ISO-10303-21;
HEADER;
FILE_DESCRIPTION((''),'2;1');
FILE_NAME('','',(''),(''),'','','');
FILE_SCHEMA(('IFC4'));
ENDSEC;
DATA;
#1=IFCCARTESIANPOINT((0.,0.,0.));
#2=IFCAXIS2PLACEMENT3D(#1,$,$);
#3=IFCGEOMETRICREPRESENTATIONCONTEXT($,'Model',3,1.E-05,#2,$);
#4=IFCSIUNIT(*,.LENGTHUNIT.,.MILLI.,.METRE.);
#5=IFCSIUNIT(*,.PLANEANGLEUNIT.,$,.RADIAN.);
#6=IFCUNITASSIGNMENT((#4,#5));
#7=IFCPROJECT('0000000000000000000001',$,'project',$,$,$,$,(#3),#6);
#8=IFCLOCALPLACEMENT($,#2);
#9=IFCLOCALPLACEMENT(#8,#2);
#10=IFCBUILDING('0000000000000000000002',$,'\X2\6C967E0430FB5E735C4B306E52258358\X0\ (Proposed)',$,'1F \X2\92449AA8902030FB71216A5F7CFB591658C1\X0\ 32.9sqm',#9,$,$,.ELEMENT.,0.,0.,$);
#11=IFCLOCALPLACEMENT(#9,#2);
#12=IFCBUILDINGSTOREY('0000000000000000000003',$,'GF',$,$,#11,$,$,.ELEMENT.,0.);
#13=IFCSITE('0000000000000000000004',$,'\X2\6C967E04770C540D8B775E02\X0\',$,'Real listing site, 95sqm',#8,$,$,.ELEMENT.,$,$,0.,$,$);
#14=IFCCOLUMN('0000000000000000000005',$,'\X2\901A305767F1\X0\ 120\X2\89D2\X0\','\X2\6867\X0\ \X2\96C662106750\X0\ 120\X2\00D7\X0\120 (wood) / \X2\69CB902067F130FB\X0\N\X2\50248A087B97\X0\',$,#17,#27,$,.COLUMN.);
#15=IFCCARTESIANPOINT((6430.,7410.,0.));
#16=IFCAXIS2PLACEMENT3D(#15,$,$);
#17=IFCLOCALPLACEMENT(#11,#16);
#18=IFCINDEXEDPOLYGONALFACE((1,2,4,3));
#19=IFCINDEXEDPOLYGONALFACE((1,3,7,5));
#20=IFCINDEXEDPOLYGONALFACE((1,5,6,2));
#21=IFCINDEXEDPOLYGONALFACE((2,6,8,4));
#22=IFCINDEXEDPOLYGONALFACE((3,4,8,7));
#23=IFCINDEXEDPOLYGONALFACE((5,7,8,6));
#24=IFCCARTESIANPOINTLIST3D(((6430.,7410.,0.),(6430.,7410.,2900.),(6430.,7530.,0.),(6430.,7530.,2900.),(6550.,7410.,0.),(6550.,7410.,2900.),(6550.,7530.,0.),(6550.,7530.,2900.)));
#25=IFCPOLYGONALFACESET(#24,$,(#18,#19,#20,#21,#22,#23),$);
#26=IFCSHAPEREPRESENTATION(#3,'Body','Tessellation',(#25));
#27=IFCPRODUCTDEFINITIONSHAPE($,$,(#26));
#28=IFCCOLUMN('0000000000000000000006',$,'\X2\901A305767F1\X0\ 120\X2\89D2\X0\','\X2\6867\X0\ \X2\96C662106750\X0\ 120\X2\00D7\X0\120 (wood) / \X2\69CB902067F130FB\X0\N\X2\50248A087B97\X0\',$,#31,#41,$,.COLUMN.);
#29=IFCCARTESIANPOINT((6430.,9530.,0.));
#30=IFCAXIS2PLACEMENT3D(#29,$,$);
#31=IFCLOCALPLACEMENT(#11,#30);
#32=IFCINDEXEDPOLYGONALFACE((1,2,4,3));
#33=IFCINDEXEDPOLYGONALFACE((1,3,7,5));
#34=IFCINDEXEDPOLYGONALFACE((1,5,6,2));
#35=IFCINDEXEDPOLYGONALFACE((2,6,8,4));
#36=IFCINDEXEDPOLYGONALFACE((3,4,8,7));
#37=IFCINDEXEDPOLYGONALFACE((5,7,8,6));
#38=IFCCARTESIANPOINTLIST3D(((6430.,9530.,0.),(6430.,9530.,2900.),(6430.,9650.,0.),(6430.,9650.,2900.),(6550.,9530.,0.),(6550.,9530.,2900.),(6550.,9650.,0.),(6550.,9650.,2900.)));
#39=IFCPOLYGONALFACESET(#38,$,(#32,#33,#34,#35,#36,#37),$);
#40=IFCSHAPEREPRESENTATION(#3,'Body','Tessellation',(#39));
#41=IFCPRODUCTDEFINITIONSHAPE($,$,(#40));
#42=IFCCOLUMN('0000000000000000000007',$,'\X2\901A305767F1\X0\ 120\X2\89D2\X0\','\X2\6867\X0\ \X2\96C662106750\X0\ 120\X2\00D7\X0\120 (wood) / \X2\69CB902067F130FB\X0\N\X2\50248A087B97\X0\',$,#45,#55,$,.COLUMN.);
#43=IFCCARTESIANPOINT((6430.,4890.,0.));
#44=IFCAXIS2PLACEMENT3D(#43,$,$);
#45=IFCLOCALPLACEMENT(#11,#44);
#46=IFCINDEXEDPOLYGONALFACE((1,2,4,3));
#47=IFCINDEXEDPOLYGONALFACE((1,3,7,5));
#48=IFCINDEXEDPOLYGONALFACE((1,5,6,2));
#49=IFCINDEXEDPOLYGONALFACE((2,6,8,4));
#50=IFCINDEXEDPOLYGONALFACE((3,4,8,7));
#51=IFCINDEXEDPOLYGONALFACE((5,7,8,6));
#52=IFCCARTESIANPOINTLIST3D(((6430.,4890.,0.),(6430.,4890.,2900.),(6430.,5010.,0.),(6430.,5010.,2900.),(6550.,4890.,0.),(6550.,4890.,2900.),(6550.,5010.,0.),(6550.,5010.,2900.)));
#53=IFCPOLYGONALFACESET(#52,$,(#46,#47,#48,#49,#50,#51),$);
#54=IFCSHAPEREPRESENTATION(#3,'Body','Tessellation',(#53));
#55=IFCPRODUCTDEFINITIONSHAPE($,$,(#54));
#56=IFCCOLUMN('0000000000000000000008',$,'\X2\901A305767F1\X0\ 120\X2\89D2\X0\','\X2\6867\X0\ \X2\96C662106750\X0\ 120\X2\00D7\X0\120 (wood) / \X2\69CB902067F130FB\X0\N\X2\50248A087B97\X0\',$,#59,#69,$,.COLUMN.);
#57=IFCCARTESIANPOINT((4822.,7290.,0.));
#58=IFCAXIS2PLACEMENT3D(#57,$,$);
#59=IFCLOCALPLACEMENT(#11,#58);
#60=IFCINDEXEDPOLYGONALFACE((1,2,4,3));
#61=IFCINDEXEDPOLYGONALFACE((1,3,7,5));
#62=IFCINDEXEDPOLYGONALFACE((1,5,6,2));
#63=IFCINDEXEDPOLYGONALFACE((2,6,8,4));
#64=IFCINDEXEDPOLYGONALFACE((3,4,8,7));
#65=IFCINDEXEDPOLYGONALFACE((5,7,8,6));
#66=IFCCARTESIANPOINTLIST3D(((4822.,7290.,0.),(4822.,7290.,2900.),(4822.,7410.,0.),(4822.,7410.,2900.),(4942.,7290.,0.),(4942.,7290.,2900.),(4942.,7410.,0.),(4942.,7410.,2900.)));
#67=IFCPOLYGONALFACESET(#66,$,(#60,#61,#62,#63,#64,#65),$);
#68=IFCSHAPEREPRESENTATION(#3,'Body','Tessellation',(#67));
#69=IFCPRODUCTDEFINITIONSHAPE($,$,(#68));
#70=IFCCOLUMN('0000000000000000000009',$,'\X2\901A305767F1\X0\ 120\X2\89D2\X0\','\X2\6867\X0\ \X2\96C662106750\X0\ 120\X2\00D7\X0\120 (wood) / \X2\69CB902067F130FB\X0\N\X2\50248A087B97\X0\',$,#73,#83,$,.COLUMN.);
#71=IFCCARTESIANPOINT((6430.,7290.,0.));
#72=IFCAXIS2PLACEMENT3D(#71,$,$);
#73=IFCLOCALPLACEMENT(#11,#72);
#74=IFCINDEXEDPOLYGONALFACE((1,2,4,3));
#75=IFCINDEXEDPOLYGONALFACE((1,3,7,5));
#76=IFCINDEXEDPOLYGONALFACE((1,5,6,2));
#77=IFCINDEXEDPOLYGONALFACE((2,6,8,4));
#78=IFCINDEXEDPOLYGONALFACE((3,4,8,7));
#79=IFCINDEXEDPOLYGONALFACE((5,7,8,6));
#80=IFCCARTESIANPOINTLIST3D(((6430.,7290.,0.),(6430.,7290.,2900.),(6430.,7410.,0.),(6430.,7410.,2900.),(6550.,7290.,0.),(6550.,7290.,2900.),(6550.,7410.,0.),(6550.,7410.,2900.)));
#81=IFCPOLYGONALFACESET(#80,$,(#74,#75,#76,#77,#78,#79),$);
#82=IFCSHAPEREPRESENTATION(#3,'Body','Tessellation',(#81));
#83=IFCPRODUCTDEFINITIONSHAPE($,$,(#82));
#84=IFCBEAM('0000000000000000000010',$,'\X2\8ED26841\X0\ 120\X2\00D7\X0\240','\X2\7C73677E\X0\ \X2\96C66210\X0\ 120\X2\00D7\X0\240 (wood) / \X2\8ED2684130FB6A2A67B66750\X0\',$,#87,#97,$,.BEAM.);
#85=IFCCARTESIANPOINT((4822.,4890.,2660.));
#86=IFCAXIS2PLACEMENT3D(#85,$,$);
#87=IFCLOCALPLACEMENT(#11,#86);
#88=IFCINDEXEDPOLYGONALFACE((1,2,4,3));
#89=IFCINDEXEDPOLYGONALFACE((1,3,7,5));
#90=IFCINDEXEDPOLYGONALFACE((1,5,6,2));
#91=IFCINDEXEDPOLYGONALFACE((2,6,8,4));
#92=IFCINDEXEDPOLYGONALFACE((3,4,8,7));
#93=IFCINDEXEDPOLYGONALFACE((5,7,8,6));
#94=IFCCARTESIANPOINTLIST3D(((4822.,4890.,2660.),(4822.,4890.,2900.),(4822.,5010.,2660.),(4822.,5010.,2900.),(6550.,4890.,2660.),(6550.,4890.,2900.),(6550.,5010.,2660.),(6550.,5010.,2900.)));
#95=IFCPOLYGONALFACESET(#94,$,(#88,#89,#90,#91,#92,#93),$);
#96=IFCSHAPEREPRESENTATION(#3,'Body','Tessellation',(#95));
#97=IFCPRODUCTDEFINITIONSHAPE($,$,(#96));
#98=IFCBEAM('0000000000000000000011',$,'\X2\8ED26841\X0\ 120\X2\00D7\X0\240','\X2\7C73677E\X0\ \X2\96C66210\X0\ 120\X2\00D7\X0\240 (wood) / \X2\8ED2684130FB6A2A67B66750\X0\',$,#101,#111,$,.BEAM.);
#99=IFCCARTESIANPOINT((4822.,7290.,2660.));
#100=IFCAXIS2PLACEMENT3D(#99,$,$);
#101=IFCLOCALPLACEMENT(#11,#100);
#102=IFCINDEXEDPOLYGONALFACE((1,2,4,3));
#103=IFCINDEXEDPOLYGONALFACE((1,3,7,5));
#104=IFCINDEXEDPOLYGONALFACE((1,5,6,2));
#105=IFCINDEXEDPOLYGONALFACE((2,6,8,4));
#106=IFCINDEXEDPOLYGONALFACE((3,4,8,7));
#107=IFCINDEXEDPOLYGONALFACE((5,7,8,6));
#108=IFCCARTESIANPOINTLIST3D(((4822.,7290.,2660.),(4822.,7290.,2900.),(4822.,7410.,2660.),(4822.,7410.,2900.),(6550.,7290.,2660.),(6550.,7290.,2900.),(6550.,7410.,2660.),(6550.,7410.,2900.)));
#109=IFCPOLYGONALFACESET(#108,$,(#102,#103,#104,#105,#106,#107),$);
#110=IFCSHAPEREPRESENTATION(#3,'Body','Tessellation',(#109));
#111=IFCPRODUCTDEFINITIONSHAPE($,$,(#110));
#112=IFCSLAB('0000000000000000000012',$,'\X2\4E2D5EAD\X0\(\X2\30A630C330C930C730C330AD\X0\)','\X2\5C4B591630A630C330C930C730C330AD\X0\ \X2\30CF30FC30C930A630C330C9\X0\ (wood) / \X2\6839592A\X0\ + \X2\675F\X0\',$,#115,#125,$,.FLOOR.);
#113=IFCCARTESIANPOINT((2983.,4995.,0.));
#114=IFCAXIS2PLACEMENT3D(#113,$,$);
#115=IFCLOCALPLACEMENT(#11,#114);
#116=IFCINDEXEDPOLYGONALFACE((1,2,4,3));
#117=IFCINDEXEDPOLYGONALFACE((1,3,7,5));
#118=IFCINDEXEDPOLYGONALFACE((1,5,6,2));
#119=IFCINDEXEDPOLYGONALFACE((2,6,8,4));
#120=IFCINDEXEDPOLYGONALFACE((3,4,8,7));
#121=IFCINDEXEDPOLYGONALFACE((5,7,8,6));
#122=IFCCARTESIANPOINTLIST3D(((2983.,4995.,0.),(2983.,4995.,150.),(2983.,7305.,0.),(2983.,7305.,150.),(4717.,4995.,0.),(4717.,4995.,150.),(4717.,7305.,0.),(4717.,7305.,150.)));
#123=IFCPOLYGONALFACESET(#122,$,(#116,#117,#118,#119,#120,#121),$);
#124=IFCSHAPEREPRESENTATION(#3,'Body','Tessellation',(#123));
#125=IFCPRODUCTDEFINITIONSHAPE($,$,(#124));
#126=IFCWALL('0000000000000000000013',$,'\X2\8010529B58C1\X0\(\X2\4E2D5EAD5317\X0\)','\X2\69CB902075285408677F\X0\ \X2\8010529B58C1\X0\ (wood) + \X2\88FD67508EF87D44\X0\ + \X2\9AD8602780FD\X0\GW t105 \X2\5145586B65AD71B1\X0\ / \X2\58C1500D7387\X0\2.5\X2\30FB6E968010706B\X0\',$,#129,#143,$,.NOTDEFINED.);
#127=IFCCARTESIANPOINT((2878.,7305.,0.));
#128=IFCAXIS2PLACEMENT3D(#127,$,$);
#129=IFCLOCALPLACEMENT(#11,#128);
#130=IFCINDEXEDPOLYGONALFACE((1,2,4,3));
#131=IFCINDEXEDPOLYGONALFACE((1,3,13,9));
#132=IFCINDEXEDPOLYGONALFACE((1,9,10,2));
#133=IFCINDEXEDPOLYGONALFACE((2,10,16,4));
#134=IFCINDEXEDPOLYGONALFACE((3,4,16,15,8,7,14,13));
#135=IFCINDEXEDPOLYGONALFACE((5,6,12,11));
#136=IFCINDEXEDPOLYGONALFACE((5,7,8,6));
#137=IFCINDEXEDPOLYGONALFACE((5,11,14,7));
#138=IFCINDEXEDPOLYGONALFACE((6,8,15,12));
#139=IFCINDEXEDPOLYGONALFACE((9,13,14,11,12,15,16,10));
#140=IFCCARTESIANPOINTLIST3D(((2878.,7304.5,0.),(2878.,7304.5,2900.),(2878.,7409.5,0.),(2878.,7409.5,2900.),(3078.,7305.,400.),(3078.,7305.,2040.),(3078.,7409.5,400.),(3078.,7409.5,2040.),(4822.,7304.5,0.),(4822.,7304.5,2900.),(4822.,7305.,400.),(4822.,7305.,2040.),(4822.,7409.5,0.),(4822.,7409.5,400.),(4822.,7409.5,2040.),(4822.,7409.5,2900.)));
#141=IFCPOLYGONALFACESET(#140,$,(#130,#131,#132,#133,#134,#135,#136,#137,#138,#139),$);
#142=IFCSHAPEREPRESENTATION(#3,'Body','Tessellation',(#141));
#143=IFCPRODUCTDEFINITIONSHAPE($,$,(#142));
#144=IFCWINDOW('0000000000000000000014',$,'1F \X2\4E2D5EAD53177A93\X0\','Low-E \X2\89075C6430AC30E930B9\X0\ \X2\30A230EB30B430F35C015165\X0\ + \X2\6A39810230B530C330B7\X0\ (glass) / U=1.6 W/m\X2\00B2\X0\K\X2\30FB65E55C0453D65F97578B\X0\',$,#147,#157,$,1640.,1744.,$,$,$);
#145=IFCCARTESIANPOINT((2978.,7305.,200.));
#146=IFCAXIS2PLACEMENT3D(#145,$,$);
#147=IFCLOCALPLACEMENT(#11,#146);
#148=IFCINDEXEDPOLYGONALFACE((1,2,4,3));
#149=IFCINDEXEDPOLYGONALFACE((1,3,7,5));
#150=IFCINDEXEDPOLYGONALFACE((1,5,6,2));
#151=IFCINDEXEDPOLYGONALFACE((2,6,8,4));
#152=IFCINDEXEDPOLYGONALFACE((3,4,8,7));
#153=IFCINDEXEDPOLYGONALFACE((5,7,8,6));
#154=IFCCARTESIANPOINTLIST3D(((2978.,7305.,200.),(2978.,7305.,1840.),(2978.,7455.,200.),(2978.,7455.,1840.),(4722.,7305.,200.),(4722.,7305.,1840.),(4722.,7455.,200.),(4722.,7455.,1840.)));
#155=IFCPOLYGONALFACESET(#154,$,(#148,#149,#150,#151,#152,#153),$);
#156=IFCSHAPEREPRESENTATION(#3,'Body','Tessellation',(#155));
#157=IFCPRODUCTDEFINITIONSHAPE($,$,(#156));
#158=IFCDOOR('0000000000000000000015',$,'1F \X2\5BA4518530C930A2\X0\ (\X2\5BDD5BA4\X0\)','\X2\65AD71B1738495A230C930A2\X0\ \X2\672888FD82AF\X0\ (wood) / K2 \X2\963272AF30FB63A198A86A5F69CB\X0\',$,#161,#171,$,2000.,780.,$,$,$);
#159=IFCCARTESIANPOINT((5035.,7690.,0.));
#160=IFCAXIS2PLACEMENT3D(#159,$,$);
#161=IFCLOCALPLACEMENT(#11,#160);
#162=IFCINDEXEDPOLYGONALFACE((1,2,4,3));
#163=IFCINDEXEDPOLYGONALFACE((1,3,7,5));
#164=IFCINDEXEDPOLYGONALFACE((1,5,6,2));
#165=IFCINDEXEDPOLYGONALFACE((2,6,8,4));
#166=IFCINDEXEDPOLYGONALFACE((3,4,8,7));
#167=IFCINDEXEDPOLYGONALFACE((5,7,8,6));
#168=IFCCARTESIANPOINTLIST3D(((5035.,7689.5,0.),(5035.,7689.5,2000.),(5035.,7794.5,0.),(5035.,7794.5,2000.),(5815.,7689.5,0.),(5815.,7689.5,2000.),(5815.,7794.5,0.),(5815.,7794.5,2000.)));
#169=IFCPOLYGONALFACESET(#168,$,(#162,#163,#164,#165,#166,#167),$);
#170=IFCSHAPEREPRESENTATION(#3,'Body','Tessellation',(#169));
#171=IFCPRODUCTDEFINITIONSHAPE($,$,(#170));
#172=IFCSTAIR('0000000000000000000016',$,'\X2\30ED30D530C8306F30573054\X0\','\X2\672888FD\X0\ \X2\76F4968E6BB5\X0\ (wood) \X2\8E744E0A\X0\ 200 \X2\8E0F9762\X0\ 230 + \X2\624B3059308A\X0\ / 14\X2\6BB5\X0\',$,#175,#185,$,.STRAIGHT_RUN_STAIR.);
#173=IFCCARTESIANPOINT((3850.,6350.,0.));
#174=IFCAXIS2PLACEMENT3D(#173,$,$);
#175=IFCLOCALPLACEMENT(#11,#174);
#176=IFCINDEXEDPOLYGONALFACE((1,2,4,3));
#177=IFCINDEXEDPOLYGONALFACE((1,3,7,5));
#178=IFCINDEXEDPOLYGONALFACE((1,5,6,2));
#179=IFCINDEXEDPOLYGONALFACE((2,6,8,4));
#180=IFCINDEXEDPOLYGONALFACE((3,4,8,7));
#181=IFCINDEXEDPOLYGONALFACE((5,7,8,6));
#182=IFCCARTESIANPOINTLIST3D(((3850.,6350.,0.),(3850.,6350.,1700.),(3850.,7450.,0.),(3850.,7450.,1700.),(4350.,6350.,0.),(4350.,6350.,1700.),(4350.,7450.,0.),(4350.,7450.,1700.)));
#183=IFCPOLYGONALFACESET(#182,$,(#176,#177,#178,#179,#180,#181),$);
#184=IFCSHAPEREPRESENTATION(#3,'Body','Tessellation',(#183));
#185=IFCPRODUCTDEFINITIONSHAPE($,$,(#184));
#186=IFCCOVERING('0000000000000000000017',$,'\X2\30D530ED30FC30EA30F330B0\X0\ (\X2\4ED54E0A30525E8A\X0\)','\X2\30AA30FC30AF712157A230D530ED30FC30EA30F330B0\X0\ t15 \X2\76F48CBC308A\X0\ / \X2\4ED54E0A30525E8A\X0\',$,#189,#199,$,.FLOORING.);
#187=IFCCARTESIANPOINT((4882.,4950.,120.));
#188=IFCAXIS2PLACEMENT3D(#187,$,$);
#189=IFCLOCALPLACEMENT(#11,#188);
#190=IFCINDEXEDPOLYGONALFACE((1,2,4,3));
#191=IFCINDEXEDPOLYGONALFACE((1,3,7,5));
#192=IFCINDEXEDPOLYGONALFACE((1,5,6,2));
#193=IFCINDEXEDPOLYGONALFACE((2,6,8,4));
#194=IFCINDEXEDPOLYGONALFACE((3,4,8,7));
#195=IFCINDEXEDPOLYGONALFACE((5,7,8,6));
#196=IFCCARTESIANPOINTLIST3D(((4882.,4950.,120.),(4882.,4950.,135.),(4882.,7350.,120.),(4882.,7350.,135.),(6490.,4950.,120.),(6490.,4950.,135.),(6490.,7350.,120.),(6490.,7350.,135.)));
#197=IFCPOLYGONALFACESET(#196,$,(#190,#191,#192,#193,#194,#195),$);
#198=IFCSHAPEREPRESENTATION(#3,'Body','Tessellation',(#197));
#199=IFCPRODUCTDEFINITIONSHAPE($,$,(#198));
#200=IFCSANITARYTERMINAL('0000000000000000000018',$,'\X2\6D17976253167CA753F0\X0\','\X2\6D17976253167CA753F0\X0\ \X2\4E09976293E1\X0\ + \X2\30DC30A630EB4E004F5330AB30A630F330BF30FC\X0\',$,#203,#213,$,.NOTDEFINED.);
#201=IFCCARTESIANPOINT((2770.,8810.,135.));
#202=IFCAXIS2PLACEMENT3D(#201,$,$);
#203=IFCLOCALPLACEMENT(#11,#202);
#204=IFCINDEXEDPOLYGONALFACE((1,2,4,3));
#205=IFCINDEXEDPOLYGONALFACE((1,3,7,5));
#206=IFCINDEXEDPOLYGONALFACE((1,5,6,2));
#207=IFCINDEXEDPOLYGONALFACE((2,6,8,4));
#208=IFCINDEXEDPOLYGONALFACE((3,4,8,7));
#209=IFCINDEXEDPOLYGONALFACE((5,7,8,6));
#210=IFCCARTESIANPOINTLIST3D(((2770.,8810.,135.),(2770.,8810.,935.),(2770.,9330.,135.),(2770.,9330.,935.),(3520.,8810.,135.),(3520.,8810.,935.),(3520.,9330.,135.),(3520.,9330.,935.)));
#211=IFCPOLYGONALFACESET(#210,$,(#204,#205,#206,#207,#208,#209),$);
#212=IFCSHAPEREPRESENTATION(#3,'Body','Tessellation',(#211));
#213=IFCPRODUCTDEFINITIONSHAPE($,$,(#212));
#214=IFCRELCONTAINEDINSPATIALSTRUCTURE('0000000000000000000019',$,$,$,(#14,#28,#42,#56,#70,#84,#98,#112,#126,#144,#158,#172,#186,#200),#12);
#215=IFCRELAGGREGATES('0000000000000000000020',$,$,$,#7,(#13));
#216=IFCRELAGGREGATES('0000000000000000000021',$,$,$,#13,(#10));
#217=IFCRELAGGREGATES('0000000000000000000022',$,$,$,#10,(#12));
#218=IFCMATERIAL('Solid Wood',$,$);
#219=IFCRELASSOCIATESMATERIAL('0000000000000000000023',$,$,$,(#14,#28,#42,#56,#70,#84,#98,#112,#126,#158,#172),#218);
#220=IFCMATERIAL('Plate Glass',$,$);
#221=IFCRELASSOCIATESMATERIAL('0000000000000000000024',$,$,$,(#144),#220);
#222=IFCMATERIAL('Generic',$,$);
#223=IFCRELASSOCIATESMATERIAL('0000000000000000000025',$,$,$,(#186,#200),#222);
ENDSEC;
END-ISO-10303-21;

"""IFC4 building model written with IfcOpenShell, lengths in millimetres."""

from ifc_helpers import new_model, si_unit, frame, frame_2d, origin, place, context, project, spatial, rectangle, extrude, material, element, fill, save


model = new_model("IFC4")

# Units and contexts
model_context = context("Model", 3, precision=1e-05, world=origin())
ifc_project = project(units=[si_unit("LENGTHUNIT", "METRE", prefix="MILLI"), si_unit("PLANEANGLEUNIT", "RADIAN")], contexts=[model_context])

# Site, building, storey
site_placement = place(None, origin())
site = spatial("IfcSite", under=ifc_project, at=site_placement, Name="沖縄県名護市", ObjectType="Real listing site, 95sqm", CompositionType="ELEMENT", RefElevation=0.0)
building_placement = place(site_placement, origin())
building = spatial("IfcBuilding", under=site, at=building_placement, Name="沖縄・平屋の別荘 (Proposed)", ObjectType="1F 鉄骨造・無機系外壁 32.9sqm", CompositionType="ELEMENT", ElevationOfRefHeight=0.0, ElevationOfTerrain=0.0)
storey_placement = place(building_placement, origin())
storey = spatial("IfcBuildingStorey", under=building, at=storey_placement, Name="GF", CompositionType="ELEMENT", Elevation=0.0)

# Columns
ifc_material_1 = material(Name="Solid Wood")
column_1_placement = place(storey_placement, frame((6430.0, 7410.0, 0.0)))
element("IfcColumn", 1, at=column_1_placement, inside=storey, material=ifc_material_1, Name="通し柱 120角", Description="桧 集成材 120×120 (wood) / 構造柱・N値計算", PredefinedType="COLUMN", context=model_context, shape_type="SweptSolid", body=[
    extrude(rectangle(XDim=120.0, YDim=120.0, at=frame_2d((60.0, 60.0))), frame((6430.0, 7410.0, 0.0)), (0.0, 0.0, 1.0), 2900.0),
])
column_2_placement = place(storey_placement, frame((6430.0, 9530.0, 0.0)))
element("IfcColumn", 2, at=column_2_placement, inside=storey, material=ifc_material_1, Name="通し柱 120角", Description="桧 集成材 120×120 (wood) / 構造柱・N値計算", PredefinedType="COLUMN", context=model_context, shape_type="SweptSolid", body=[
    extrude(rectangle(XDim=120.0, YDim=120.0, at=frame_2d((60.0, 60.0))), frame((6430.0, 9530.0, 0.0)), (0.0, 0.0, 1.0), 2900.0),
])
column_3_placement = place(storey_placement, frame((6430.0, 4890.0, 0.0)))
element("IfcColumn", 3, at=column_3_placement, inside=storey, material=ifc_material_1, Name="通し柱 120角", Description="桧 集成材 120×120 (wood) / 構造柱・N値計算", PredefinedType="COLUMN", context=model_context, shape_type="SweptSolid", body=[
    extrude(rectangle(XDim=120.0, YDim=120.0, at=frame_2d((60.0, 60.0))), frame((6430.0, 4890.0, 0.0)), (0.0, 0.0, 1.0), 2900.0),
])
column_4_placement = place(storey_placement, frame((4822.0, 7290.0, 0.0)))
element("IfcColumn", 4, at=column_4_placement, inside=storey, material=ifc_material_1, Name="通し柱 120角", Description="桧 集成材 120×120 (wood) / 構造柱・N値計算", PredefinedType="COLUMN", context=model_context, shape_type="SweptSolid", body=[
    extrude(rectangle(XDim=120.0, YDim=120.0, at=frame_2d((60.0, 60.0))), frame((4822.0, 7290.0, 0.0)), (0.0, 0.0, 1.0), 2900.0),
])
column_5_placement = place(storey_placement, frame((6430.0, 7290.0, 0.0)))
element("IfcColumn", 5, at=column_5_placement, inside=storey, material=ifc_material_1, Name="通し柱 120角", Description="桧 集成材 120×120 (wood) / 構造柱・N値計算", PredefinedType="COLUMN", context=model_context, shape_type="SweptSolid", body=[
    extrude(rectangle(XDim=120.0, YDim=120.0, at=frame_2d((60.0, 60.0))), frame((6430.0, 7290.0, 0.0)), (0.0, 0.0, 1.0), 2900.0),
])

# Beams
beam_1_placement = place(storey_placement, frame((4822.0, 4890.0, 2660.0)))
element("IfcBeam", 6, at=beam_1_placement, inside=storey, material=ifc_material_1, Name="軒桁 120×240", Description="米松 集成 120×240 (wood) / 軒桁・横架材", PredefinedType="BEAM", context=model_context, shape_type="SweptSolid", body=[
    extrude(rectangle(XDim=1728.0, YDim=120.0, at=frame_2d((864.0, 60.0))), frame((4822.0, 4890.0, 2660.0)), (0.0, 0.0, 1.0), 240.0),
])
beam_2_placement = place(storey_placement, frame((4822.0, 7290.0, 2660.0)))
element("IfcBeam", 7, at=beam_2_placement, inside=storey, material=ifc_material_1, Name="軒桁 120×240", Description="米松 集成 120×240 (wood) / 軒桁・横架材", PredefinedType="BEAM", context=model_context, shape_type="SweptSolid", body=[
    extrude(rectangle(XDim=1728.0, YDim=120.0, at=frame_2d((864.0, 60.0))), frame((4822.0, 7290.0, 2660.0)), (0.0, 0.0, 1.0), 240.0),
])

# Slab
slab_placement = place(storey_placement, frame((2983.0, 4995.0, 0.0)))
element("IfcSlab", 8, at=slab_placement, inside=storey, material=ifc_material_1, Name="中庭(ウッドデッキ)", Description="屋外ウッドデッキ ハードウッド (wood) / 根太 + 束", PredefinedType="FLOOR", context=model_context, shape_type="SweptSolid", body=[
    extrude(rectangle(XDim=1734.0, YDim=2310.0, at=frame_2d((867.0, 1155.0))), frame((2983.0, 4995.0, 0.0)), (0.0, 0.0, 1.0), 150.0),
])

# Wall, opening, window
wall_1_placement = place(storey_placement, frame((2878.0, 7305.0, 0.0)))
wall_1 = element("IfcWall", 9, at=wall_1_placement, inside=storey, material=ifc_material_1, Name="耐力壁(中庭北)", Description="構造用合板 耐力壁 (wood) + 製材軸組 + 高性能GW t105 充填断熱 / 壁倍率2.5・準耐火", PredefinedType="NOTDEFINED", context=model_context, shape_type="SweptSolid", body=[
    extrude(rectangle(XDim=1944.0, YDim=105.0, at=frame_2d((972.0, 52.0))), frame((2878.0, 7305.0, 0.0)), (0.0, 0.0, 1.0), 2900.0),
])
opening_placement = place(storey_placement, frame((2978.0, 7305.0, 200.0)))
opening = element("IfcOpeningElement", 10, at=opening_placement, cuts=wall_1, PredefinedType="NOTDEFINED", context=model_context, shape_type="SweptSolid", body=[
    extrude(rectangle(XDim=1744.0, YDim=150.0, at=frame_2d((872.0, 75.0))), frame((2978.0, 7305.0, 200.0)), (0.0, 0.0, 1.0), 1640.0),
])
ifc_material_2 = material(Name="Plate Glass")
window_placement = place(storey_placement, frame((2978.0, 7305.0, 200.0)))
window = element("IfcWindow", 11, at=window_placement, inside=storey, material=ifc_material_2, Name="1F 中庭北窓", Description="Low-E 複層ガラス アルゴン封入 + 樹脂サッシ (glass) / U=1.6 W/m²K・日射取得型", OverallHeight=1640.0, OverallWidth=1744.0, context=model_context, shape_type="SweptSolid", body=[
    extrude(rectangle(XDim=1744.0, YDim=150.0, at=frame_2d((872.0, 75.0))), frame((2978.0, 7305.0, 200.0)), (0.0, 0.0, 1.0), 1640.0),
])
fill(opening, window)

# Door
door_placement = place(storey_placement, frame((5035.0, 7690.0, 0.0)))
element("IfcDoor", 12, at=door_placement, inside=storey, material=ifc_material_1, Name="1F 室内ドア (寝室)", Description="断熱玄関ドア 木製芯 (wood) / K2 防犯・採風機構", OverallHeight=2000.0, OverallWidth=780.0, context=model_context, shape_type="SweptSolid", body=[
    extrude(rectangle(XDim=780.0, YDim=105.0, at=frame_2d((390.0, 52.0))), frame((5035.0, 7690.0, 0.0)), (0.0, 0.0, 1.0), 2000.0),
])

# Stair
stair_placement = place(storey_placement, frame((3850.0, 6350.0, 0.0)))
element("IfcStair", 13, at=stair_placement, inside=storey, material=ifc_material_1, Name="ロフトはしご", Description="木製 直階段 (wood) 蹴上 200 踏面 230 + 手すり / 14段", PredefinedType="STRAIGHT_RUN_STAIR", context=model_context, shape_type="SweptSolid", body=[
    extrude(rectangle(XDim=500.0, YDim=1100.0, at=frame_2d((250.0, 550.0))), frame((3850.0, 6350.0, 0.0)), (0.0, 0.0, 1.0), 1700.0),
])

# Covering
ifc_material_3 = material(Name="Generic")
covering_placement = place(storey_placement, frame((4882.0, 4950.0, 120.0)))
element("IfcCovering", 14, at=covering_placement, inside=storey, material=ifc_material_3, Name="フローリング (仕上げ床)", Description="オーク無垢フローリング t15 直貼り / 仕上げ床", PredefinedType="FLOORING", context=model_context, shape_type="SweptSolid", body=[
    extrude(rectangle(XDim=1608.0, YDim=2400.0, at=frame_2d((804.0, 1200.0))), frame((4882.0, 4950.0, 120.0)), (0.0, 0.0, 1.0), 15.0),
])

# Sanitary terminal
sanitary_terminal_1_placement = place(storey_placement, frame((2770.0, 8810.0, 135.0)))
element("IfcSanitaryTerminal", 15, at=sanitary_terminal_1_placement, inside=storey, material=ifc_material_3, Name="洗面化粧台", Description="洗面化粧台 三面鏡 + ボウル一体カウンター", PredefinedType="NOTDEFINED", context=model_context, shape_type="SweptSolid", body=[
    extrude(rectangle(XDim=750.0, YDim=520.0, at=frame_2d((375.0, 260.0))), frame((2770.0, 8810.0, 135.0)), (0.0, 0.0, 1.0), 800.0),
])

save(model, "model.ifc")
